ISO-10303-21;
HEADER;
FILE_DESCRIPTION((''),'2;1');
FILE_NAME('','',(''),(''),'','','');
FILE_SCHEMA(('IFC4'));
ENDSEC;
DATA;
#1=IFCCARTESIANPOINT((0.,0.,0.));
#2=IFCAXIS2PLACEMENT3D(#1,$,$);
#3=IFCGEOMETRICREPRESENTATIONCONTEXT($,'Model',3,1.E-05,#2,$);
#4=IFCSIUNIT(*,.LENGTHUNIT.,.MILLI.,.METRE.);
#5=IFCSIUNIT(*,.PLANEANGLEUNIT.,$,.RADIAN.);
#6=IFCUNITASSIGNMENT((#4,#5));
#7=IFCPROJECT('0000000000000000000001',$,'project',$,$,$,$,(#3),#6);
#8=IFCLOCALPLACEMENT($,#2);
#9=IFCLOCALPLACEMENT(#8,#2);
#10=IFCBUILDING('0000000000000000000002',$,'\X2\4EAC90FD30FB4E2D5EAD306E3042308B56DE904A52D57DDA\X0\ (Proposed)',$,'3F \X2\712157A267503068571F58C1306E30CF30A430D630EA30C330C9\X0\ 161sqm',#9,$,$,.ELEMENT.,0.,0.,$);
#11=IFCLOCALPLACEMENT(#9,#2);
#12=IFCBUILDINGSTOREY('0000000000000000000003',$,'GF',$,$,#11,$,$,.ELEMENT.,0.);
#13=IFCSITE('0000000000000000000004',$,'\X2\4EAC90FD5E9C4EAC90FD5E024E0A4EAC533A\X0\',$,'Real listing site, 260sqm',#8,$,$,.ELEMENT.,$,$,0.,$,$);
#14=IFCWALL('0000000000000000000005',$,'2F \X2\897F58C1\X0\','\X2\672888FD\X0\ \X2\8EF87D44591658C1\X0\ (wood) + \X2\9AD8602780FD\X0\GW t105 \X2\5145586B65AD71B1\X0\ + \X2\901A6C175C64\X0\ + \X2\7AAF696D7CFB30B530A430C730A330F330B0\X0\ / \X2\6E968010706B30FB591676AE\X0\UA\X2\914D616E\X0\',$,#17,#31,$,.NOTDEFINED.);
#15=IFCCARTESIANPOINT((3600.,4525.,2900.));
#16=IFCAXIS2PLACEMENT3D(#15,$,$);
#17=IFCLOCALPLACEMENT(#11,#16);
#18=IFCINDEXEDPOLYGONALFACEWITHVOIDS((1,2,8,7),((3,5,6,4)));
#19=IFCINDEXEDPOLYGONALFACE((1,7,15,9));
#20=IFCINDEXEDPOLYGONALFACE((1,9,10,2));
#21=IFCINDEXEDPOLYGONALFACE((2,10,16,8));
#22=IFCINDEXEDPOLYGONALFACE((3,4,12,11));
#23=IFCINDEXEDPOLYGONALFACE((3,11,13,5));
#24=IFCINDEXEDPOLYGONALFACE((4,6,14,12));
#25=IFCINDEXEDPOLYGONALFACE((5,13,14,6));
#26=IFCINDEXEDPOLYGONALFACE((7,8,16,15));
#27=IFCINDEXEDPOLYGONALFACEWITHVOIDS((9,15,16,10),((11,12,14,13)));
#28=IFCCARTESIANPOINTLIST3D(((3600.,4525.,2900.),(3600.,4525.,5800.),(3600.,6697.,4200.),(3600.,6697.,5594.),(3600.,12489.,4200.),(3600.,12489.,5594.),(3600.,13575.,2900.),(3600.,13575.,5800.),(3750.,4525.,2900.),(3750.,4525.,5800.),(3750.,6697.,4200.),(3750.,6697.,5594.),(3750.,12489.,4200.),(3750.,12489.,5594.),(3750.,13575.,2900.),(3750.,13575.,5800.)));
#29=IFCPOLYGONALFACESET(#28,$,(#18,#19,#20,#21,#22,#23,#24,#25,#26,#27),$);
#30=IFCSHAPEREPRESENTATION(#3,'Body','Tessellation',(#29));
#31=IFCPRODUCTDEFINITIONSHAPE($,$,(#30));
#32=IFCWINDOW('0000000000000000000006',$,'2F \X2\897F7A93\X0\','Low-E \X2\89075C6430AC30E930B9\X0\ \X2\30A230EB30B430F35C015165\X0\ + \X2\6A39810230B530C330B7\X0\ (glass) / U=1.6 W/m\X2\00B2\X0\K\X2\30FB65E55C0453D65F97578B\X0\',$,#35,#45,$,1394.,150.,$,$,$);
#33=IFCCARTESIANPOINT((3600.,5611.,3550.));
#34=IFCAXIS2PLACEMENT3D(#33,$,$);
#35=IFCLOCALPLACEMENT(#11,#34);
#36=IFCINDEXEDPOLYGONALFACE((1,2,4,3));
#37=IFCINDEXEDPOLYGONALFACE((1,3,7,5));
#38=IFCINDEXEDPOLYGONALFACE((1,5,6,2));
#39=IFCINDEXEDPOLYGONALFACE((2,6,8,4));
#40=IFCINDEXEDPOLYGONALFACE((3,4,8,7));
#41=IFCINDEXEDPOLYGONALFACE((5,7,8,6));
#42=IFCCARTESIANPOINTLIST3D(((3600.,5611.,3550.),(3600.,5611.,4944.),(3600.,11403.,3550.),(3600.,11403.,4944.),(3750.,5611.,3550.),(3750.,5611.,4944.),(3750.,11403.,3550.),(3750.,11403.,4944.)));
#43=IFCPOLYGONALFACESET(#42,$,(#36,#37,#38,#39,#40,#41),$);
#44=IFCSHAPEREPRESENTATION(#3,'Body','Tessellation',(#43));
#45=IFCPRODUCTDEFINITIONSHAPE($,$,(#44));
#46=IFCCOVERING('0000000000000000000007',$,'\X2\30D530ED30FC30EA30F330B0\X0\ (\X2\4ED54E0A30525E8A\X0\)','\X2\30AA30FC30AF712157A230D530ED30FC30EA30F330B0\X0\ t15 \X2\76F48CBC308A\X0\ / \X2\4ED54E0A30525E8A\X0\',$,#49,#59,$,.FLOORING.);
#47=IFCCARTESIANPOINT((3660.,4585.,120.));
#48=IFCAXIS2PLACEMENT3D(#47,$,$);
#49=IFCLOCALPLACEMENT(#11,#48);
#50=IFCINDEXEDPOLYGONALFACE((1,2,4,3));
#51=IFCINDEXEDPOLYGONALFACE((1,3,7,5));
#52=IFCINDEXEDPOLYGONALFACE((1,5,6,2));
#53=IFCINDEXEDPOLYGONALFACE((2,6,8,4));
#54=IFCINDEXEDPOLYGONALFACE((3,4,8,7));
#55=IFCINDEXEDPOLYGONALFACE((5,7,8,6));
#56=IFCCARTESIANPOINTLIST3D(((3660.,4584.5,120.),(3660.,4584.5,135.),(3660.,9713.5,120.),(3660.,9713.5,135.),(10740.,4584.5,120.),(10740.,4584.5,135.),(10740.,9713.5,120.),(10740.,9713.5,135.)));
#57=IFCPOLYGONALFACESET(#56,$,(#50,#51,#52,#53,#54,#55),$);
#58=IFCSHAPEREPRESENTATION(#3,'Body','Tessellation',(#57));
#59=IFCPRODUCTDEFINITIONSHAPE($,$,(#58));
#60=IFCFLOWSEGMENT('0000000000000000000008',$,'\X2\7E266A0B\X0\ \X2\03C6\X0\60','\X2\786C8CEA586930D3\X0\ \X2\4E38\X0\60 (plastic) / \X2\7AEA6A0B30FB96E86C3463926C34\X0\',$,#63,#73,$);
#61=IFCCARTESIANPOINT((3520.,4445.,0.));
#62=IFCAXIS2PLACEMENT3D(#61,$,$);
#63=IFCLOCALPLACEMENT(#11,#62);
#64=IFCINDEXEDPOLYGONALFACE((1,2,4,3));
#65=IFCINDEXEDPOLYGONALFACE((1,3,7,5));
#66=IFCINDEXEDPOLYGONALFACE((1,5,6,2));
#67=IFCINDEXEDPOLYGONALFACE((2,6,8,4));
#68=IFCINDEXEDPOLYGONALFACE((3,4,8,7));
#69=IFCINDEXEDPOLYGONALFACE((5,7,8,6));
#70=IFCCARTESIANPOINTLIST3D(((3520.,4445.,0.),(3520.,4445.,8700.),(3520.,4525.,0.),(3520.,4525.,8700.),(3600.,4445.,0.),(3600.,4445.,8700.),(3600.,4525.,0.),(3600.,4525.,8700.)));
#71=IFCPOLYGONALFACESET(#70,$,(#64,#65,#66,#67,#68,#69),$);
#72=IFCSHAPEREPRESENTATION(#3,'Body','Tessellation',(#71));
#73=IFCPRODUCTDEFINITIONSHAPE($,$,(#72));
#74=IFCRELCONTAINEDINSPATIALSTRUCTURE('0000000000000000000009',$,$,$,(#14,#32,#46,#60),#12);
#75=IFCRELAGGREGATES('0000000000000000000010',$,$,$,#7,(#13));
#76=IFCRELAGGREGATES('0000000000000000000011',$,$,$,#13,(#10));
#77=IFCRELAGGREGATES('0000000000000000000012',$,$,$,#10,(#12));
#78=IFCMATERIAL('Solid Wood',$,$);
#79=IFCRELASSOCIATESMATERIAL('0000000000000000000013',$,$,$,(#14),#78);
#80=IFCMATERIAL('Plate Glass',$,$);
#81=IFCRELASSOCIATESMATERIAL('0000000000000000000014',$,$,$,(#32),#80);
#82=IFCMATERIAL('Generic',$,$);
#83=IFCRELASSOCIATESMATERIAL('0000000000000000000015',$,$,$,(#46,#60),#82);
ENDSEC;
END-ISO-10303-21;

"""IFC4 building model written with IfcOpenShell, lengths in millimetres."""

from ifc_helpers import new_model, si_unit, frame, frame_2d, origin, place, context, project, spatial, rectangle, extrude, material, element, fill, save


model = new_model("IFC4")

# Units and contexts
model_context = context("Model", 3, precision=1e-05, world=origin())
ifc_project = project(units=[si_unit("LENGTHUNIT", "METRE", prefix="MILLI"), si_unit("PLANEANGLEUNIT", "RADIAN")], contexts=[model_context])

# Site, building, storey
site_placement = place(None, origin())
site = spatial("IfcSite", under=ifc_project, at=site_placement, Name="京都府京都市上京区", ObjectType="Real listing site, 260sqm", CompositionType="ELEMENT", RefElevation=0.0)
building_placement = place(site_placement, origin())
building = spatial("IfcBuilding", under=site, at=building_placement, Name="京都・中庭のある回遊動線 (Proposed)", ObjectType="3F 無垢材と土壁のハイブリッド 161sqm", CompositionType="ELEMENT", ElevationOfRefHeight=0.0, ElevationOfTerrain=0.0)
storey_placement = place(building_placement, origin())
storey = spatial("IfcBuildingStorey", under=building, at=storey_placement, Name="GF", CompositionType="ELEMENT", Elevation=0.0)

# Shared definitions
ifc_material_1 = material(Name="Solid Wood")

# Shared definitions
ifc_material_2 = material(Name="Plate Glass")

# Wall, opening, window
wall_1_placement = place(storey_placement, frame((3600.0, 4525.0, 2900.0)))
wall_1 = element("IfcWall", 1, at=wall_1_placement, inside=storey, material=ifc_material_1, Name="2F 西壁", Description="木製 軸組外壁 (wood) + 高性能GW t105 充填断熱 + 通気層 + 窯業系サイディング / 準耐火・外皮UA配慮", PredefinedType="NOTDEFINED", context=model_context, shape_type="SweptSolid", body=[
    extrude(rectangle(XDim=150.0, YDim=9050.0, at=frame_2d((75.0, 4525.0))), frame((3600.0, 4525.0, 2900.0)), (0.0, 0.0, 1.0), 2900.0),
])
opening_1_placement = place(storey_placement, frame((3600.0, 5611.0, 3550.0)))
opening_1 = element("IfcOpeningElement", 2, at=opening_1_placement, cuts=wall_1, PredefinedType="NOTDEFINED", context=model_context, shape_type="SweptSolid", body=[
    extrude(rectangle(XDim=150.0, YDim=5792.0, at=frame_2d((75.0, 2896.0))), frame((3600.0, 5611.0, 3550.0)), (0.0, 0.0, 1.0), 1394.0),
])
window_1_placement = place(storey_placement, frame((3600.0, 5611.0, 3550.0)))
window_1 = element("IfcWindow", 3, at=window_1_placement, inside=storey, material=ifc_material_2, Name="2F 西窓", Description="Low-E 複層ガラス アルゴン封入 + 樹脂サッシ (glass) / U=1.6 W/m²K・日射取得型", OverallHeight=1394.0, OverallWidth=150.0, context=model_context, shape_type="SweptSolid", body=[
    extrude(rectangle(XDim=150.0, YDim=5792.0, at=frame_2d((75.0, 2896.0))), frame((3600.0, 5611.0, 3550.0)), (0.0, 0.0, 1.0), 1394.0),
])
fill(opening_1, window_1)

# Covering
ifc_material_3 = material(Name="Generic")
covering_placement = place(storey_placement, frame((3660.0, 4585.0, 120.0)))
element("IfcCovering", 4, at=covering_placement, inside=storey, material=ifc_material_3, Name="フローリング (仕上げ床)", Description="オーク無垢フローリング t15 直貼り / 仕上げ床", PredefinedType="FLOORING", context=model_context, shape_type="SweptSolid", body=[
    extrude(rectangle(XDim=7080.0, YDim=5129.0, at=frame_2d((3540.0, 2564.0))), frame((3660.0, 4585.0, 120.0)), (0.0, 0.0, 1.0), 15.0),
])

# Flow segment
flow_segment_placement = place(storey_placement, frame((3520.0, 4445.0, 0.0)))
element("IfcFlowSegment", 5, at=flow_segment_placement, inside=storey, material=ifc_material_3, Name="縦樋 φ60", Description="硬質塩ビ 丸60 (plastic) / 竪樋・雨水排水", context=model_context, shape_type="SweptSolid", body=[
    extrude(rectangle(XDim=80.0, YDim=80.0, at=frame_2d((40.0, 40.0))), frame((3520.0, 4445.0, 0.0)), (0.0, 0.0, 1.0), 8700.0),
])

save(model, "model.ifc")
